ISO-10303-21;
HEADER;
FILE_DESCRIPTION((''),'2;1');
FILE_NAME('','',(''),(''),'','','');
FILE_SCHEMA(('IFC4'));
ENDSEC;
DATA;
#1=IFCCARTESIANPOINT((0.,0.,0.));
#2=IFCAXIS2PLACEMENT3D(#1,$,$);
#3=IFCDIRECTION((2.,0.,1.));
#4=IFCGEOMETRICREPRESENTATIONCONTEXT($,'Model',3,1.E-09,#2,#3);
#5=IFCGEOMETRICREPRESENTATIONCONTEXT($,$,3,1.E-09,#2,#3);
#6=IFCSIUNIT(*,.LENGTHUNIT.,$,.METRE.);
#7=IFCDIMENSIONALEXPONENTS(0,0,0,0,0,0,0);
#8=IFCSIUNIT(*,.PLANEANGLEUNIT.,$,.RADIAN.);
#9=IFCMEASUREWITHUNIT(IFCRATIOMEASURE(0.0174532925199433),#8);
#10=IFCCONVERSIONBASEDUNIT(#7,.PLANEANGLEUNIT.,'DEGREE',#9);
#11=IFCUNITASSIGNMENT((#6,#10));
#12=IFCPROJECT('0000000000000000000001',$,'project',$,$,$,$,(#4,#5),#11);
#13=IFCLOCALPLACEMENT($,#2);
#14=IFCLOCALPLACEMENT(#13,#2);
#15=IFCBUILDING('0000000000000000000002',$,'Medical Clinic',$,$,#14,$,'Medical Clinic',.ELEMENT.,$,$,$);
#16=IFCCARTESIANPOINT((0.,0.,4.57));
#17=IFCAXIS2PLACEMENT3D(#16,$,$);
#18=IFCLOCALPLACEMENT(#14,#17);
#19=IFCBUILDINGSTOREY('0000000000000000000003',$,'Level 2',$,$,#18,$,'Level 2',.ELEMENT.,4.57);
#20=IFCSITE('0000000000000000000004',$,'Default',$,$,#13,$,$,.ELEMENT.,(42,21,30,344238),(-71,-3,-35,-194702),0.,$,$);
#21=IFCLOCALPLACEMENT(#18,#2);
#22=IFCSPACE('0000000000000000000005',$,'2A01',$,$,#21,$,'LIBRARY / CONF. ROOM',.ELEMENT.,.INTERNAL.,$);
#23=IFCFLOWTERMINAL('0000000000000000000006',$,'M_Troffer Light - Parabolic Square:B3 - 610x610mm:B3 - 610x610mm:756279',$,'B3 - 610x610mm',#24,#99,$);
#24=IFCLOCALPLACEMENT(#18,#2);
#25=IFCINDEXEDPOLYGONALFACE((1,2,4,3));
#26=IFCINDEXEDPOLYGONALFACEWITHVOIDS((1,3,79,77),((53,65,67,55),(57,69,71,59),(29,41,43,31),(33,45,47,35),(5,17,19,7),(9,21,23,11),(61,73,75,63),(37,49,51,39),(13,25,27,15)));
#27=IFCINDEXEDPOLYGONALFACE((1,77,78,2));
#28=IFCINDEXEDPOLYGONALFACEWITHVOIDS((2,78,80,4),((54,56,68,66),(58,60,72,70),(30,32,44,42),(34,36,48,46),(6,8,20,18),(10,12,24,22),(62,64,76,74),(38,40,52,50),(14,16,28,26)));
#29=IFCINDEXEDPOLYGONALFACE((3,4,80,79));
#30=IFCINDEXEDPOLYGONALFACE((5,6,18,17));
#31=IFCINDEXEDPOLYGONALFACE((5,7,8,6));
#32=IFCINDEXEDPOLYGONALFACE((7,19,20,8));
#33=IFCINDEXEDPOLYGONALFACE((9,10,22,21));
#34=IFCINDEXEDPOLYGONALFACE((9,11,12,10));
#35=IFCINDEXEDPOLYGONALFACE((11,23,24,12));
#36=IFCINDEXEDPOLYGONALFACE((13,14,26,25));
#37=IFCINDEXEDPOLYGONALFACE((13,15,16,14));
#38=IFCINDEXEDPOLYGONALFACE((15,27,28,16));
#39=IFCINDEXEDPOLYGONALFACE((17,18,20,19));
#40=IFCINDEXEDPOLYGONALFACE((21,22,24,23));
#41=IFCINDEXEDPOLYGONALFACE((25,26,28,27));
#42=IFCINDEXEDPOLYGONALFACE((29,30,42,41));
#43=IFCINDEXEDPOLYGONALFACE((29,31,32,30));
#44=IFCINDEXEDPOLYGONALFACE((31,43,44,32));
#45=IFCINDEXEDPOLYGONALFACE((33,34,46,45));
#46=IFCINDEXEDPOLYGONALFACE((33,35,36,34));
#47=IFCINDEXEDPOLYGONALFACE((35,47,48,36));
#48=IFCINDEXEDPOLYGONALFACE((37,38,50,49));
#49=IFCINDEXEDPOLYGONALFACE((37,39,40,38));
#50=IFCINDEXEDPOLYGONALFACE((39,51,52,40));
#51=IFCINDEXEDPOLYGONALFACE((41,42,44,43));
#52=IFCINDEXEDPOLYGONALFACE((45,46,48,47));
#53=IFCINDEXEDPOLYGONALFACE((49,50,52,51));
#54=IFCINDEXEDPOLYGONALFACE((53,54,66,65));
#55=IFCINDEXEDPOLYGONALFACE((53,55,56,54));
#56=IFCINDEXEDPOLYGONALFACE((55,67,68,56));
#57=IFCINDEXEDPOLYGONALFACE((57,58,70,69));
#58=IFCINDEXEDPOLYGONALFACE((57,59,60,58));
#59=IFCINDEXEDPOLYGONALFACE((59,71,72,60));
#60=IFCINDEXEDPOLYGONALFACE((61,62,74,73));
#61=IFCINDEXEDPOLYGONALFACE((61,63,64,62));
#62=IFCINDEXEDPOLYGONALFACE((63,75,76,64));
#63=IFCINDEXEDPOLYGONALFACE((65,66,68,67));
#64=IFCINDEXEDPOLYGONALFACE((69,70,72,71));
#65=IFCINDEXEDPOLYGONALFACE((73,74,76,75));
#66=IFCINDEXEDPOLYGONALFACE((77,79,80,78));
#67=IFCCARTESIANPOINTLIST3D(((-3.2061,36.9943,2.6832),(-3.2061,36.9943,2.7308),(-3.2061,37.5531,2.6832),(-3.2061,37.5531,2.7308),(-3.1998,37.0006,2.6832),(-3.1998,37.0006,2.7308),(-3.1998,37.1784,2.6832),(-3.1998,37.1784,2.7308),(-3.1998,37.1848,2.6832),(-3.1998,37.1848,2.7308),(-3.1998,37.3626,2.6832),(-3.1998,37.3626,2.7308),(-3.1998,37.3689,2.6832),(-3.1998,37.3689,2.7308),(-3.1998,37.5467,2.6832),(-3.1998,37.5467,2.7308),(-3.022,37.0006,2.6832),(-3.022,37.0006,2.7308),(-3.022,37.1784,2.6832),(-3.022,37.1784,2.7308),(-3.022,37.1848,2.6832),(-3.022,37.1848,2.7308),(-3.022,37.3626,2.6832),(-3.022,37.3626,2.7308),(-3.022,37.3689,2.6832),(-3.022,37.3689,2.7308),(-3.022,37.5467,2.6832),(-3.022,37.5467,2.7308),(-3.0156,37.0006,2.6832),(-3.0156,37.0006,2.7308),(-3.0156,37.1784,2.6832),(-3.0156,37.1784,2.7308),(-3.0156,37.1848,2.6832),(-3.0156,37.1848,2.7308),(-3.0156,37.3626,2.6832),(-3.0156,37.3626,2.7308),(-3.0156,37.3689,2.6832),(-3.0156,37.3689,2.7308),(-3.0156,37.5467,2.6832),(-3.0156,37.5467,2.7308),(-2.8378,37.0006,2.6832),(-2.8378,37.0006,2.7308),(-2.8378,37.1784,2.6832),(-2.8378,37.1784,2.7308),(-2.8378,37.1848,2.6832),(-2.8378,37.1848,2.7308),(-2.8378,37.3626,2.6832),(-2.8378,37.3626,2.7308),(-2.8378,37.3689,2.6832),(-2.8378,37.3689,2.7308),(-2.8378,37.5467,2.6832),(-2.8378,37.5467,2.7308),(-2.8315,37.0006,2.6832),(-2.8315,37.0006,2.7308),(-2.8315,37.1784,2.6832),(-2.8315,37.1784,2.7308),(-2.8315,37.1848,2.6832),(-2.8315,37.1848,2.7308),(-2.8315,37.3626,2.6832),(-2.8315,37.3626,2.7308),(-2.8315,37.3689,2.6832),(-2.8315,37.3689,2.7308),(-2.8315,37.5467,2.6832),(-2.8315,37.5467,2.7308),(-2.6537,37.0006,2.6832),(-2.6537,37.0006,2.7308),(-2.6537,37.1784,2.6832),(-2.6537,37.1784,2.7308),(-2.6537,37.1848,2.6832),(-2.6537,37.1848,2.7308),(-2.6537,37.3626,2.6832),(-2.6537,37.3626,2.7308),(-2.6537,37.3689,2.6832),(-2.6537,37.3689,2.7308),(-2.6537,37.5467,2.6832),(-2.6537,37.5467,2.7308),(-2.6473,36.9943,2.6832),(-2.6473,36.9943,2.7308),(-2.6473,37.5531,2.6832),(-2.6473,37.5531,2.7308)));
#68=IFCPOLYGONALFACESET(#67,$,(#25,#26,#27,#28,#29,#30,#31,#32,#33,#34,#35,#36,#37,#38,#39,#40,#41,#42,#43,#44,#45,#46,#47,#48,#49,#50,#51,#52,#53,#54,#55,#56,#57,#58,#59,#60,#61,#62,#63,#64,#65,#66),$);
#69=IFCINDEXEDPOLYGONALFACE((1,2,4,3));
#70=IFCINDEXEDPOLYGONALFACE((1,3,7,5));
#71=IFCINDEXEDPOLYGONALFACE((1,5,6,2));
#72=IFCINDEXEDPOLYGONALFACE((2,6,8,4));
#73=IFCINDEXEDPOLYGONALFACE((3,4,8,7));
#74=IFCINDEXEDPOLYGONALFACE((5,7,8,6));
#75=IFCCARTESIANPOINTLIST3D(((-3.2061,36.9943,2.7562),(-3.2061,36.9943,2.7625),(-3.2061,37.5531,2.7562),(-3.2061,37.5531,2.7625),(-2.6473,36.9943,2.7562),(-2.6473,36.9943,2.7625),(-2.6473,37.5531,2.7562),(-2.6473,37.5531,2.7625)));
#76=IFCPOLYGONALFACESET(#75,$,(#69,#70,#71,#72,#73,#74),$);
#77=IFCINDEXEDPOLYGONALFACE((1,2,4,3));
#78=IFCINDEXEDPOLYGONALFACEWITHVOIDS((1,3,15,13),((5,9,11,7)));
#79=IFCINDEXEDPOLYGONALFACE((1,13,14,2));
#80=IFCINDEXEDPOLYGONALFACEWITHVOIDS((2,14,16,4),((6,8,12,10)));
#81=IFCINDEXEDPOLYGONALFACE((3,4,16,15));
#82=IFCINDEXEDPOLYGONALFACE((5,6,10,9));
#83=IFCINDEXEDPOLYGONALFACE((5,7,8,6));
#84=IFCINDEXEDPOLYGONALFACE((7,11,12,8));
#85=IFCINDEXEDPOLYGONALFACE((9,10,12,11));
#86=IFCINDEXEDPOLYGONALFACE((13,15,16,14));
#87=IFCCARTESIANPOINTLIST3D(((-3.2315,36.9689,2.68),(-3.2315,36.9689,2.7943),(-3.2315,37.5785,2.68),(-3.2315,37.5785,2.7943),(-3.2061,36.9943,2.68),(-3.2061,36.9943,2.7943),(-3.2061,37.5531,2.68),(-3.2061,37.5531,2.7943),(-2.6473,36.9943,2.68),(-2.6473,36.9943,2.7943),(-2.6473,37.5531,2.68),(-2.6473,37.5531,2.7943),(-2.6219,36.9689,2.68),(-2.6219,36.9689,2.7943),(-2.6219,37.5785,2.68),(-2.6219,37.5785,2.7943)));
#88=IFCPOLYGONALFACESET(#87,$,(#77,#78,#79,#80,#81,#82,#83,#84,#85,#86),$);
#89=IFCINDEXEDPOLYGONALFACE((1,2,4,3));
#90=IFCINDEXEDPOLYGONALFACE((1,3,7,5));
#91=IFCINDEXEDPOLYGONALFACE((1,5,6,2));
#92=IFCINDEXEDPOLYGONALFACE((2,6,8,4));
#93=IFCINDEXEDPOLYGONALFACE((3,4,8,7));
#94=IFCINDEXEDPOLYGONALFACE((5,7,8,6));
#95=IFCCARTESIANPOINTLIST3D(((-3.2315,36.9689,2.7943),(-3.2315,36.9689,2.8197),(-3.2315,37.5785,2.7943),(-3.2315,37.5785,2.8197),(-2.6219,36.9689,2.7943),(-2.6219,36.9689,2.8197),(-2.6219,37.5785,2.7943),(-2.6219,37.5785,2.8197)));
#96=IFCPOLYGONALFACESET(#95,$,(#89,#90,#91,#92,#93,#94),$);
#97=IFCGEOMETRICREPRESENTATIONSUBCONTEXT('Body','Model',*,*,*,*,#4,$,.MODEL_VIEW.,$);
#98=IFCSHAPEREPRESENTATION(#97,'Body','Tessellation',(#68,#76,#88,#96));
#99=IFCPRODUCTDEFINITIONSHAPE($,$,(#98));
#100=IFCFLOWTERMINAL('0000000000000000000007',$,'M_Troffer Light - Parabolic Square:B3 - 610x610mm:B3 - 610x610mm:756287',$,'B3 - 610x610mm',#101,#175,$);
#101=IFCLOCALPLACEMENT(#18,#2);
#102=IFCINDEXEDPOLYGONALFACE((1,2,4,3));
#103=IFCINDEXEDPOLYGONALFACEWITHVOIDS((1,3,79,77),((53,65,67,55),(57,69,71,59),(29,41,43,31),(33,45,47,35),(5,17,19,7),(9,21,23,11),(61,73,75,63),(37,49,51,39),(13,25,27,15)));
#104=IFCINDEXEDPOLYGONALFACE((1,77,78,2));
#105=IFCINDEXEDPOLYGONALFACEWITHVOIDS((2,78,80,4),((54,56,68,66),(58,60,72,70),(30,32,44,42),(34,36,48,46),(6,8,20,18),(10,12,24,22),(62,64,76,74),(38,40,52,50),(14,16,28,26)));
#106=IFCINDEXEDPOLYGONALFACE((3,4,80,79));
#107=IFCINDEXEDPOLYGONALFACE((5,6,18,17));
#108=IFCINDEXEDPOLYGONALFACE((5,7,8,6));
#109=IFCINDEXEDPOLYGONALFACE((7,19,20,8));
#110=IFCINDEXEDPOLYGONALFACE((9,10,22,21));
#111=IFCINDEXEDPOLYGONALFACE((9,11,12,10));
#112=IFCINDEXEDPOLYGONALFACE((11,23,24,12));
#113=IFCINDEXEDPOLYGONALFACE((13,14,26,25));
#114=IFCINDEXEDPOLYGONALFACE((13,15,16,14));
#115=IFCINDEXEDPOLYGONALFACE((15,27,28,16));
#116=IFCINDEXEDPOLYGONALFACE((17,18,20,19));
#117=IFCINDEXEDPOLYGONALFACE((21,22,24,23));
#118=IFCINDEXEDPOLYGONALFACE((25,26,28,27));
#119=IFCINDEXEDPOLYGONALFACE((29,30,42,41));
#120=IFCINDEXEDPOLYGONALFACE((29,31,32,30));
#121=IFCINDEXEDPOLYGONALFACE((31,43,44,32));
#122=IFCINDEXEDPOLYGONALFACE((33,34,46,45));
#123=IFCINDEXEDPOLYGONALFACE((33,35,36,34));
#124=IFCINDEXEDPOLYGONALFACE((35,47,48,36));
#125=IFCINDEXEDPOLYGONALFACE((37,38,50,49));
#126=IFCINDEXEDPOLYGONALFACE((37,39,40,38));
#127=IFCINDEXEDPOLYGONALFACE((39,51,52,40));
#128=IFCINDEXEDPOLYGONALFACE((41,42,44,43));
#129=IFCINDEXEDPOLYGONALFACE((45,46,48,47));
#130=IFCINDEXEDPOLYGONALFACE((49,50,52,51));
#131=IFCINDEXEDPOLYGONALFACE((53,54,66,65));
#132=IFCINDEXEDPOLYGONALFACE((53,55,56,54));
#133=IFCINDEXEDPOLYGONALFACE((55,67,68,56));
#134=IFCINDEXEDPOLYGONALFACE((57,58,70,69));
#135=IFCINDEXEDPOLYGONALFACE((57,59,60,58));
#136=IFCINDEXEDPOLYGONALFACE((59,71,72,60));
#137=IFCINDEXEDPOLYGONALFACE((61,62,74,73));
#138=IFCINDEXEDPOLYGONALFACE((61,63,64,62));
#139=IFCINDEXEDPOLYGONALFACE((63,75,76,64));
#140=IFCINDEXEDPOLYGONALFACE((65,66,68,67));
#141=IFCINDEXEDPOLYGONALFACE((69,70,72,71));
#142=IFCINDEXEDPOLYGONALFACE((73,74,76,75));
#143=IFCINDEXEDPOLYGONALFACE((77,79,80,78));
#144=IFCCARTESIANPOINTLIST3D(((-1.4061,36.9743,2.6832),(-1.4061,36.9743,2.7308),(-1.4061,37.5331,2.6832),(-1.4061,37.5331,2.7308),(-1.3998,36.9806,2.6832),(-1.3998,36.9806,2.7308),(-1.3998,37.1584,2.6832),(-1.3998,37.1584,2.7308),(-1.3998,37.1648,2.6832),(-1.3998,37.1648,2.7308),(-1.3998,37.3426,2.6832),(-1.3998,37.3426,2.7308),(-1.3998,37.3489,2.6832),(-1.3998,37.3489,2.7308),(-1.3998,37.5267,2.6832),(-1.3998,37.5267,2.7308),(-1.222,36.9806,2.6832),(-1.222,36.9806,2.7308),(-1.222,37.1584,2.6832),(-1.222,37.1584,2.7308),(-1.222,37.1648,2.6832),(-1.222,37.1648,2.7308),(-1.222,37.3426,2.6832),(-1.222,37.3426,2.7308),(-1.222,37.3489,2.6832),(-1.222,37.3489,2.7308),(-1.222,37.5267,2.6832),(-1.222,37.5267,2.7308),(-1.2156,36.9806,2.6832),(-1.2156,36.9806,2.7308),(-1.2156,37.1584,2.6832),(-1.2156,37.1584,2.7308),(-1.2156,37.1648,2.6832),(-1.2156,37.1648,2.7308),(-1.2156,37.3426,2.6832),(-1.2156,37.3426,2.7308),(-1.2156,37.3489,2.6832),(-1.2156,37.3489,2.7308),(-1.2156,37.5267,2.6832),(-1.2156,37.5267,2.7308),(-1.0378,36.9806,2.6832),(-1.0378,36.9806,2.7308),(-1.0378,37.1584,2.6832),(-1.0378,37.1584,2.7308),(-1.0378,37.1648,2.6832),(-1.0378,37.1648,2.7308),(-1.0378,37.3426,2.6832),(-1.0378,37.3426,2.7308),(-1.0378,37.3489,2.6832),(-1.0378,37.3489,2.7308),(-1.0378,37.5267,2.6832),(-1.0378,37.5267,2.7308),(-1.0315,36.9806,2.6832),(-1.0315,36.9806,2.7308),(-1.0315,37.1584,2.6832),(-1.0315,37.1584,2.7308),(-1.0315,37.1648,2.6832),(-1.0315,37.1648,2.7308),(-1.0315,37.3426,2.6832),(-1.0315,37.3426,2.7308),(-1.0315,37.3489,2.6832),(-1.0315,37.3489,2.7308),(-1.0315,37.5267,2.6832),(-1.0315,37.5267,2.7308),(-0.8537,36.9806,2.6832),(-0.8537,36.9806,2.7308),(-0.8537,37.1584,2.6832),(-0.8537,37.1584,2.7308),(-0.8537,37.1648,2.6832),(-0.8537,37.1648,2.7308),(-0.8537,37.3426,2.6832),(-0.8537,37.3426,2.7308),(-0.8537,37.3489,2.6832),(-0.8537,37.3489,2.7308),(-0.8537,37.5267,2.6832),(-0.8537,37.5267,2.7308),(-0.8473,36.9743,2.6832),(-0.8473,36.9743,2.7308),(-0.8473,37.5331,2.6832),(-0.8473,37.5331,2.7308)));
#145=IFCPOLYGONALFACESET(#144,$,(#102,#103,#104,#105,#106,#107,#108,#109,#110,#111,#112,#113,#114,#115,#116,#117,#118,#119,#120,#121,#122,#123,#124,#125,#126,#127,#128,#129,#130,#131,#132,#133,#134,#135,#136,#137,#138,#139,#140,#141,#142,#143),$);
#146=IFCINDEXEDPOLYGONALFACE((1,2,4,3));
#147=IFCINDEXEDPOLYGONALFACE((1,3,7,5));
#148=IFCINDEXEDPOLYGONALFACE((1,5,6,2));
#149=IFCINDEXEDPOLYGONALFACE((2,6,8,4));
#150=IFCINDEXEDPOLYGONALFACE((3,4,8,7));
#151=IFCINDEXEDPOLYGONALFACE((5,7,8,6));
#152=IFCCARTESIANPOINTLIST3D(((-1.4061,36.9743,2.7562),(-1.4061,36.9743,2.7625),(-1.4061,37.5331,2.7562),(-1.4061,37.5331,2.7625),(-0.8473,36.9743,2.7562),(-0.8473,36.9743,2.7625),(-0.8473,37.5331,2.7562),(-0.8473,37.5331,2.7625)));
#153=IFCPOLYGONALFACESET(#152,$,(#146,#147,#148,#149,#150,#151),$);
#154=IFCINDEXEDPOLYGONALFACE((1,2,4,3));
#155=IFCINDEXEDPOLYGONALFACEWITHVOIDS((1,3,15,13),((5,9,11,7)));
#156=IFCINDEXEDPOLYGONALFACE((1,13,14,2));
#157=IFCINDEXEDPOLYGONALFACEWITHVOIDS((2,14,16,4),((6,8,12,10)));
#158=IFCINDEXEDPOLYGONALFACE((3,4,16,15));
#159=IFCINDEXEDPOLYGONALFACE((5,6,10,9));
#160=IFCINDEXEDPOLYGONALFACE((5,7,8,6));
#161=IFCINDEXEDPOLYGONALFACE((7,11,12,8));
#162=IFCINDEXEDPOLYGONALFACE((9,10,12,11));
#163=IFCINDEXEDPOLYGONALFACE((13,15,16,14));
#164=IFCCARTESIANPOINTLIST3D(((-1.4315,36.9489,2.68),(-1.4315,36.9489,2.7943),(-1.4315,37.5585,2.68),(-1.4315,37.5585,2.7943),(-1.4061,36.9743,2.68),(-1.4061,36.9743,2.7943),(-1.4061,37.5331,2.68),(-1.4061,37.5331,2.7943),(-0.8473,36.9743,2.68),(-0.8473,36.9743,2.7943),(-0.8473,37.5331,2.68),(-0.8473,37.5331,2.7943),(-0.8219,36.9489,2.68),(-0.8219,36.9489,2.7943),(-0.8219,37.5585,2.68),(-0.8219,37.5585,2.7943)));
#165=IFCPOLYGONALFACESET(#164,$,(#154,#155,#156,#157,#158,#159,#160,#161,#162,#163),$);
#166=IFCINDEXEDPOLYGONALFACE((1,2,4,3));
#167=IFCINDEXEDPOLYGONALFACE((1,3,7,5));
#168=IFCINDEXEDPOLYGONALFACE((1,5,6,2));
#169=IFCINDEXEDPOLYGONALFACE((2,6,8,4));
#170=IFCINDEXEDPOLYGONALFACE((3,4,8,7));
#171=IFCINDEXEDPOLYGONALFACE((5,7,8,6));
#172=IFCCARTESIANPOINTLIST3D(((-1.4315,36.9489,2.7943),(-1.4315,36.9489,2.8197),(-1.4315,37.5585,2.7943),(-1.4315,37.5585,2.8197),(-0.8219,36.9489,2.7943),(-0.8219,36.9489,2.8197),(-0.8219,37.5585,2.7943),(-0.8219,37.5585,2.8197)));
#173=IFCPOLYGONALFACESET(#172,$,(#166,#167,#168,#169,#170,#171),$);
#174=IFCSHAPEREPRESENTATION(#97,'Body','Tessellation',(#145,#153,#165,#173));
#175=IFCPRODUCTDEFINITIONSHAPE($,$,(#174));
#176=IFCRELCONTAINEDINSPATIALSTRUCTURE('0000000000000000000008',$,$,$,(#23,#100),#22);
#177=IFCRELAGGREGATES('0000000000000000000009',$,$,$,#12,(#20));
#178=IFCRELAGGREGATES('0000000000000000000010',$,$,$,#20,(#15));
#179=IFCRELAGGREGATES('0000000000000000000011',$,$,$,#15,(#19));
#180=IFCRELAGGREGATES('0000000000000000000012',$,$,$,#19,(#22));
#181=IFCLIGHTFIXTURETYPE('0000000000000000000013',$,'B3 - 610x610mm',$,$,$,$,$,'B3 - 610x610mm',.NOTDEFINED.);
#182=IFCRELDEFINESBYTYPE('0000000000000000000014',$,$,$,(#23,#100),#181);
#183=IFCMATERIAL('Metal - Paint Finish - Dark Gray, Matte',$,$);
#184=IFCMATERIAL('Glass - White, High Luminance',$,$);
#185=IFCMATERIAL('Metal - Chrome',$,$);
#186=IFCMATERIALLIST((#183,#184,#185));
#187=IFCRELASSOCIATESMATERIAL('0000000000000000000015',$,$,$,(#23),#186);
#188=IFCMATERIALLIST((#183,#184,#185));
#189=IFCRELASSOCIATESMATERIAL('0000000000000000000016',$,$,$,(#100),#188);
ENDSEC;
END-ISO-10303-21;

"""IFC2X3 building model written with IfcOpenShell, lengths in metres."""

from ifc_helpers import new_model, entity, si_unit, converted_unit, direction, frame, origin, origin_2d_with_axis, place, context, subcontext, project, spatial, polyline, rectangle, outline, extrude, source, transform, mapped, material, material_list, type_object, type_shapes, element, save


model = new_model("IFC2X3")

# Units and contexts
model_context = context("Model", 3, precision=1e-09, world=origin(), true_north=direction((2.0, 0.0, 1.0)))
context_of_model = context(None, 3, precision=1e-09, world=origin(), true_north=direction((2.0, 0.0, 1.0)))
body_context = subcontext(model_context, "Body", "Model", "MODEL_VIEW")
ifc_project = project(units=[si_unit("LENGTHUNIT", "METRE"), converted_unit("PLANEANGLEUNIT", "DEGREE", entity("IfcRatioMeasure", 0.0174532925199433), si_unit("PLANEANGLEUNIT", "RADIAN"), dimensions=[0, 0, 0, 0, 0, 0, 0])], contexts=[model_context, context_of_model])

# Site, building, storey, space
site_placement = place(None, origin())
site = spatial("IfcSite", under=ifc_project, at=site_placement, Name="Default", CompositionType="ELEMENT", RefLatitude=(42, 21, 30, 344238), RefLongitude=(-71, -3, -35, -194702), RefElevation=0.0)
building_placement = place(site_placement, origin())
building = spatial("IfcBuilding", under=site, at=building_placement, Name="Medical Clinic", LongName="Medical Clinic", CompositionType="ELEMENT")
storey_placement = place(building_placement, frame((0.0, 0.0, 4.57)))
storey = spatial("IfcBuildingStorey", under=building, at=storey_placement, Name="Level 2", LongName="Level 2", CompositionType="ELEMENT", Elevation=4.57)
space_1_placement = place(storey_placement, origin())
space_1 = spatial("IfcSpace", under=storey, at=space_1_placement, Name="2A01", LongName="LIBRARY / CONF. ROOM", CompositionType="ELEMENT", InteriorOrExteriorSpace="INTERNAL")

# Flow terminals
ifc_material_1 = material(Name="Metal - Paint Finish - Dark Gray, Matte")
ifc_material_2 = material(Name="Glass - White, High Luminance")
ifc_material_3 = material(Name="Metal - Chrome")
light_fixture_type_1 = type_object("IfcLightFixtureType", Name="B3 - 610x610mm", ElementType="B3 - 610x610mm", PredefinedType="NOTDEFINED")
shared_shape_1 = source(origin(), body_context, "Body", "SweptSolid", [
    extrude(outline(polyline([(-0.2794, -0.2794), (0.2794, -0.2794), (0.2794, 0.2794), (-0.2794, 0.2794), (-0.2794, -0.2794)]), holes=[polyline([(-0.0952, 0.0953), (-0.273, 0.0953), (-0.273, 0.2731), (-0.0952, 0.2731), (-0.0952, 0.0953)]), polyline([(0.2731, 0.0953), (0.0953, 0.0953), (0.0953, 0.2731), (0.2731, 0.2731), (0.2731, 0.0953)]), polyline([(-0.0889, 0.2731), (0.0889, 0.2731), (0.0889, 0.0953), (-0.0889, 0.0953), (-0.0889, 0.2731)]), polyline([(0.2731, -0.273), (0.0953, -0.273), (0.0953, -0.0952), (0.2731, -0.0952), (0.2731, -0.273)]), polyline([(0.0889, -0.273), (-0.0889, -0.273), (-0.0889, -0.0952), (0.0889, -0.0952), (0.0889, -0.273)]), polyline([(-0.0952, -0.273), (-0.273, -0.273), (-0.273, -0.0952), (-0.0952, -0.0952), (-0.0952, -0.273)]), polyline([(-0.0952, -0.0889), (-0.273, -0.0889), (-0.273, 0.0889), (-0.0952, 0.0889), (-0.0952, -0.0889)]), polyline([(0.0889, -0.0889), (-0.0889, -0.0889), (-0.0889, 0.0889), (0.0889, 0.0889), (0.0889, -0.0889)]), polyline([(0.2731, -0.0889), (0.0953, -0.0889), (0.0953, 0.0889), (0.2731, 0.0889), (0.2731, -0.0889)])]), frame((0.0, -0.3048, -0.0508), z_axis=(0.0, 0.0, 1.0), x_axis=(-1.0, 0.0, 0.0)), (0.0, 0.0, 1.0), 0.0476),
    extrude(rectangle(XDim=0.5588, YDim=0.5588, at=origin_2d_with_axis()), frame((0.0, -0.3048, -0.0825), z_axis=(0.0, 0.0, 1.0), x_axis=(-1.0, 0.0, 0.0)), (0.0, 0.0, 1.0), 0.0064),
    extrude(outline(polyline([(-0.3048, -0.3048), (0.3048, -0.3048), (0.3048, 0.3048), (-0.3048, 0.3048), (-0.3048, -0.3048)]), holes=[polyline([(0.2794, 0.2794), (0.2794, -0.2794), (-0.2794, -0.2794), (-0.2794, 0.2794), (0.2794, 0.2794)])]), frame((0.0, -0.3048, -0.1143)), (0.0, 0.0, 1.0), 0.1143),
    extrude(rectangle(XDim=0.6096, YDim=0.6096, at=origin_2d_with_axis()), frame((0.0, -0.3048, -0.1397), z_axis=(0.0, 0.0, 1.0), x_axis=(-1.0, 0.0, 0.0)), (0.0, 0.0, 1.0), 0.0254),
])
type_shapes(light_fixture_type_1, [shared_shape_1])
ifc_material_list_1 = material_list([ifc_material_1, ifc_material_2, ifc_material_3])
flow_terminal_1_placement = place(space_1_placement, frame((-2.9267, 36.9689, 2.68), z_axis=(0.0, 0.0, -1.0), x_axis=(1.0, 0.0, 0.0)))
element("IfcFlowTerminal", 1, at=flow_terminal_1_placement, inside=space_1, type_object=light_fixture_type_1, material=ifc_material_list_1, Name="M_Troffer Light - Parabolic Square:B3 - 610x610mm:B3 - 610x610mm:756279", ObjectType="B3 - 610x610mm", context=body_context, shape_type="MappedRepresentation", body=[
    mapped(shared_shape_1, transform((0.0, 0.0, 0.0), scale=1.0)),
])
ifc_material_list_2 = material_list([ifc_material_1, ifc_material_2, ifc_material_3])
flow_terminal_2_placement = place(space_1_placement, frame((-1.1267, 36.9489, 2.68), z_axis=(0.0, 0.0, -1.0), x_axis=(1.0, 0.0, 0.0)))
element("IfcFlowTerminal", 2, at=flow_terminal_2_placement, inside=space_1, type_object=light_fixture_type_1, material=ifc_material_list_2, Name="M_Troffer Light - Parabolic Square:B3 - 610x610mm:B3 - 610x610mm:756287", ObjectType="B3 - 610x610mm", context=body_context, shape_type="MappedRepresentation", body=[
    mapped(shared_shape_1, transform((0.0, 0.0, 0.0), scale=1.0)),
])

save(model, "model.ifc")
